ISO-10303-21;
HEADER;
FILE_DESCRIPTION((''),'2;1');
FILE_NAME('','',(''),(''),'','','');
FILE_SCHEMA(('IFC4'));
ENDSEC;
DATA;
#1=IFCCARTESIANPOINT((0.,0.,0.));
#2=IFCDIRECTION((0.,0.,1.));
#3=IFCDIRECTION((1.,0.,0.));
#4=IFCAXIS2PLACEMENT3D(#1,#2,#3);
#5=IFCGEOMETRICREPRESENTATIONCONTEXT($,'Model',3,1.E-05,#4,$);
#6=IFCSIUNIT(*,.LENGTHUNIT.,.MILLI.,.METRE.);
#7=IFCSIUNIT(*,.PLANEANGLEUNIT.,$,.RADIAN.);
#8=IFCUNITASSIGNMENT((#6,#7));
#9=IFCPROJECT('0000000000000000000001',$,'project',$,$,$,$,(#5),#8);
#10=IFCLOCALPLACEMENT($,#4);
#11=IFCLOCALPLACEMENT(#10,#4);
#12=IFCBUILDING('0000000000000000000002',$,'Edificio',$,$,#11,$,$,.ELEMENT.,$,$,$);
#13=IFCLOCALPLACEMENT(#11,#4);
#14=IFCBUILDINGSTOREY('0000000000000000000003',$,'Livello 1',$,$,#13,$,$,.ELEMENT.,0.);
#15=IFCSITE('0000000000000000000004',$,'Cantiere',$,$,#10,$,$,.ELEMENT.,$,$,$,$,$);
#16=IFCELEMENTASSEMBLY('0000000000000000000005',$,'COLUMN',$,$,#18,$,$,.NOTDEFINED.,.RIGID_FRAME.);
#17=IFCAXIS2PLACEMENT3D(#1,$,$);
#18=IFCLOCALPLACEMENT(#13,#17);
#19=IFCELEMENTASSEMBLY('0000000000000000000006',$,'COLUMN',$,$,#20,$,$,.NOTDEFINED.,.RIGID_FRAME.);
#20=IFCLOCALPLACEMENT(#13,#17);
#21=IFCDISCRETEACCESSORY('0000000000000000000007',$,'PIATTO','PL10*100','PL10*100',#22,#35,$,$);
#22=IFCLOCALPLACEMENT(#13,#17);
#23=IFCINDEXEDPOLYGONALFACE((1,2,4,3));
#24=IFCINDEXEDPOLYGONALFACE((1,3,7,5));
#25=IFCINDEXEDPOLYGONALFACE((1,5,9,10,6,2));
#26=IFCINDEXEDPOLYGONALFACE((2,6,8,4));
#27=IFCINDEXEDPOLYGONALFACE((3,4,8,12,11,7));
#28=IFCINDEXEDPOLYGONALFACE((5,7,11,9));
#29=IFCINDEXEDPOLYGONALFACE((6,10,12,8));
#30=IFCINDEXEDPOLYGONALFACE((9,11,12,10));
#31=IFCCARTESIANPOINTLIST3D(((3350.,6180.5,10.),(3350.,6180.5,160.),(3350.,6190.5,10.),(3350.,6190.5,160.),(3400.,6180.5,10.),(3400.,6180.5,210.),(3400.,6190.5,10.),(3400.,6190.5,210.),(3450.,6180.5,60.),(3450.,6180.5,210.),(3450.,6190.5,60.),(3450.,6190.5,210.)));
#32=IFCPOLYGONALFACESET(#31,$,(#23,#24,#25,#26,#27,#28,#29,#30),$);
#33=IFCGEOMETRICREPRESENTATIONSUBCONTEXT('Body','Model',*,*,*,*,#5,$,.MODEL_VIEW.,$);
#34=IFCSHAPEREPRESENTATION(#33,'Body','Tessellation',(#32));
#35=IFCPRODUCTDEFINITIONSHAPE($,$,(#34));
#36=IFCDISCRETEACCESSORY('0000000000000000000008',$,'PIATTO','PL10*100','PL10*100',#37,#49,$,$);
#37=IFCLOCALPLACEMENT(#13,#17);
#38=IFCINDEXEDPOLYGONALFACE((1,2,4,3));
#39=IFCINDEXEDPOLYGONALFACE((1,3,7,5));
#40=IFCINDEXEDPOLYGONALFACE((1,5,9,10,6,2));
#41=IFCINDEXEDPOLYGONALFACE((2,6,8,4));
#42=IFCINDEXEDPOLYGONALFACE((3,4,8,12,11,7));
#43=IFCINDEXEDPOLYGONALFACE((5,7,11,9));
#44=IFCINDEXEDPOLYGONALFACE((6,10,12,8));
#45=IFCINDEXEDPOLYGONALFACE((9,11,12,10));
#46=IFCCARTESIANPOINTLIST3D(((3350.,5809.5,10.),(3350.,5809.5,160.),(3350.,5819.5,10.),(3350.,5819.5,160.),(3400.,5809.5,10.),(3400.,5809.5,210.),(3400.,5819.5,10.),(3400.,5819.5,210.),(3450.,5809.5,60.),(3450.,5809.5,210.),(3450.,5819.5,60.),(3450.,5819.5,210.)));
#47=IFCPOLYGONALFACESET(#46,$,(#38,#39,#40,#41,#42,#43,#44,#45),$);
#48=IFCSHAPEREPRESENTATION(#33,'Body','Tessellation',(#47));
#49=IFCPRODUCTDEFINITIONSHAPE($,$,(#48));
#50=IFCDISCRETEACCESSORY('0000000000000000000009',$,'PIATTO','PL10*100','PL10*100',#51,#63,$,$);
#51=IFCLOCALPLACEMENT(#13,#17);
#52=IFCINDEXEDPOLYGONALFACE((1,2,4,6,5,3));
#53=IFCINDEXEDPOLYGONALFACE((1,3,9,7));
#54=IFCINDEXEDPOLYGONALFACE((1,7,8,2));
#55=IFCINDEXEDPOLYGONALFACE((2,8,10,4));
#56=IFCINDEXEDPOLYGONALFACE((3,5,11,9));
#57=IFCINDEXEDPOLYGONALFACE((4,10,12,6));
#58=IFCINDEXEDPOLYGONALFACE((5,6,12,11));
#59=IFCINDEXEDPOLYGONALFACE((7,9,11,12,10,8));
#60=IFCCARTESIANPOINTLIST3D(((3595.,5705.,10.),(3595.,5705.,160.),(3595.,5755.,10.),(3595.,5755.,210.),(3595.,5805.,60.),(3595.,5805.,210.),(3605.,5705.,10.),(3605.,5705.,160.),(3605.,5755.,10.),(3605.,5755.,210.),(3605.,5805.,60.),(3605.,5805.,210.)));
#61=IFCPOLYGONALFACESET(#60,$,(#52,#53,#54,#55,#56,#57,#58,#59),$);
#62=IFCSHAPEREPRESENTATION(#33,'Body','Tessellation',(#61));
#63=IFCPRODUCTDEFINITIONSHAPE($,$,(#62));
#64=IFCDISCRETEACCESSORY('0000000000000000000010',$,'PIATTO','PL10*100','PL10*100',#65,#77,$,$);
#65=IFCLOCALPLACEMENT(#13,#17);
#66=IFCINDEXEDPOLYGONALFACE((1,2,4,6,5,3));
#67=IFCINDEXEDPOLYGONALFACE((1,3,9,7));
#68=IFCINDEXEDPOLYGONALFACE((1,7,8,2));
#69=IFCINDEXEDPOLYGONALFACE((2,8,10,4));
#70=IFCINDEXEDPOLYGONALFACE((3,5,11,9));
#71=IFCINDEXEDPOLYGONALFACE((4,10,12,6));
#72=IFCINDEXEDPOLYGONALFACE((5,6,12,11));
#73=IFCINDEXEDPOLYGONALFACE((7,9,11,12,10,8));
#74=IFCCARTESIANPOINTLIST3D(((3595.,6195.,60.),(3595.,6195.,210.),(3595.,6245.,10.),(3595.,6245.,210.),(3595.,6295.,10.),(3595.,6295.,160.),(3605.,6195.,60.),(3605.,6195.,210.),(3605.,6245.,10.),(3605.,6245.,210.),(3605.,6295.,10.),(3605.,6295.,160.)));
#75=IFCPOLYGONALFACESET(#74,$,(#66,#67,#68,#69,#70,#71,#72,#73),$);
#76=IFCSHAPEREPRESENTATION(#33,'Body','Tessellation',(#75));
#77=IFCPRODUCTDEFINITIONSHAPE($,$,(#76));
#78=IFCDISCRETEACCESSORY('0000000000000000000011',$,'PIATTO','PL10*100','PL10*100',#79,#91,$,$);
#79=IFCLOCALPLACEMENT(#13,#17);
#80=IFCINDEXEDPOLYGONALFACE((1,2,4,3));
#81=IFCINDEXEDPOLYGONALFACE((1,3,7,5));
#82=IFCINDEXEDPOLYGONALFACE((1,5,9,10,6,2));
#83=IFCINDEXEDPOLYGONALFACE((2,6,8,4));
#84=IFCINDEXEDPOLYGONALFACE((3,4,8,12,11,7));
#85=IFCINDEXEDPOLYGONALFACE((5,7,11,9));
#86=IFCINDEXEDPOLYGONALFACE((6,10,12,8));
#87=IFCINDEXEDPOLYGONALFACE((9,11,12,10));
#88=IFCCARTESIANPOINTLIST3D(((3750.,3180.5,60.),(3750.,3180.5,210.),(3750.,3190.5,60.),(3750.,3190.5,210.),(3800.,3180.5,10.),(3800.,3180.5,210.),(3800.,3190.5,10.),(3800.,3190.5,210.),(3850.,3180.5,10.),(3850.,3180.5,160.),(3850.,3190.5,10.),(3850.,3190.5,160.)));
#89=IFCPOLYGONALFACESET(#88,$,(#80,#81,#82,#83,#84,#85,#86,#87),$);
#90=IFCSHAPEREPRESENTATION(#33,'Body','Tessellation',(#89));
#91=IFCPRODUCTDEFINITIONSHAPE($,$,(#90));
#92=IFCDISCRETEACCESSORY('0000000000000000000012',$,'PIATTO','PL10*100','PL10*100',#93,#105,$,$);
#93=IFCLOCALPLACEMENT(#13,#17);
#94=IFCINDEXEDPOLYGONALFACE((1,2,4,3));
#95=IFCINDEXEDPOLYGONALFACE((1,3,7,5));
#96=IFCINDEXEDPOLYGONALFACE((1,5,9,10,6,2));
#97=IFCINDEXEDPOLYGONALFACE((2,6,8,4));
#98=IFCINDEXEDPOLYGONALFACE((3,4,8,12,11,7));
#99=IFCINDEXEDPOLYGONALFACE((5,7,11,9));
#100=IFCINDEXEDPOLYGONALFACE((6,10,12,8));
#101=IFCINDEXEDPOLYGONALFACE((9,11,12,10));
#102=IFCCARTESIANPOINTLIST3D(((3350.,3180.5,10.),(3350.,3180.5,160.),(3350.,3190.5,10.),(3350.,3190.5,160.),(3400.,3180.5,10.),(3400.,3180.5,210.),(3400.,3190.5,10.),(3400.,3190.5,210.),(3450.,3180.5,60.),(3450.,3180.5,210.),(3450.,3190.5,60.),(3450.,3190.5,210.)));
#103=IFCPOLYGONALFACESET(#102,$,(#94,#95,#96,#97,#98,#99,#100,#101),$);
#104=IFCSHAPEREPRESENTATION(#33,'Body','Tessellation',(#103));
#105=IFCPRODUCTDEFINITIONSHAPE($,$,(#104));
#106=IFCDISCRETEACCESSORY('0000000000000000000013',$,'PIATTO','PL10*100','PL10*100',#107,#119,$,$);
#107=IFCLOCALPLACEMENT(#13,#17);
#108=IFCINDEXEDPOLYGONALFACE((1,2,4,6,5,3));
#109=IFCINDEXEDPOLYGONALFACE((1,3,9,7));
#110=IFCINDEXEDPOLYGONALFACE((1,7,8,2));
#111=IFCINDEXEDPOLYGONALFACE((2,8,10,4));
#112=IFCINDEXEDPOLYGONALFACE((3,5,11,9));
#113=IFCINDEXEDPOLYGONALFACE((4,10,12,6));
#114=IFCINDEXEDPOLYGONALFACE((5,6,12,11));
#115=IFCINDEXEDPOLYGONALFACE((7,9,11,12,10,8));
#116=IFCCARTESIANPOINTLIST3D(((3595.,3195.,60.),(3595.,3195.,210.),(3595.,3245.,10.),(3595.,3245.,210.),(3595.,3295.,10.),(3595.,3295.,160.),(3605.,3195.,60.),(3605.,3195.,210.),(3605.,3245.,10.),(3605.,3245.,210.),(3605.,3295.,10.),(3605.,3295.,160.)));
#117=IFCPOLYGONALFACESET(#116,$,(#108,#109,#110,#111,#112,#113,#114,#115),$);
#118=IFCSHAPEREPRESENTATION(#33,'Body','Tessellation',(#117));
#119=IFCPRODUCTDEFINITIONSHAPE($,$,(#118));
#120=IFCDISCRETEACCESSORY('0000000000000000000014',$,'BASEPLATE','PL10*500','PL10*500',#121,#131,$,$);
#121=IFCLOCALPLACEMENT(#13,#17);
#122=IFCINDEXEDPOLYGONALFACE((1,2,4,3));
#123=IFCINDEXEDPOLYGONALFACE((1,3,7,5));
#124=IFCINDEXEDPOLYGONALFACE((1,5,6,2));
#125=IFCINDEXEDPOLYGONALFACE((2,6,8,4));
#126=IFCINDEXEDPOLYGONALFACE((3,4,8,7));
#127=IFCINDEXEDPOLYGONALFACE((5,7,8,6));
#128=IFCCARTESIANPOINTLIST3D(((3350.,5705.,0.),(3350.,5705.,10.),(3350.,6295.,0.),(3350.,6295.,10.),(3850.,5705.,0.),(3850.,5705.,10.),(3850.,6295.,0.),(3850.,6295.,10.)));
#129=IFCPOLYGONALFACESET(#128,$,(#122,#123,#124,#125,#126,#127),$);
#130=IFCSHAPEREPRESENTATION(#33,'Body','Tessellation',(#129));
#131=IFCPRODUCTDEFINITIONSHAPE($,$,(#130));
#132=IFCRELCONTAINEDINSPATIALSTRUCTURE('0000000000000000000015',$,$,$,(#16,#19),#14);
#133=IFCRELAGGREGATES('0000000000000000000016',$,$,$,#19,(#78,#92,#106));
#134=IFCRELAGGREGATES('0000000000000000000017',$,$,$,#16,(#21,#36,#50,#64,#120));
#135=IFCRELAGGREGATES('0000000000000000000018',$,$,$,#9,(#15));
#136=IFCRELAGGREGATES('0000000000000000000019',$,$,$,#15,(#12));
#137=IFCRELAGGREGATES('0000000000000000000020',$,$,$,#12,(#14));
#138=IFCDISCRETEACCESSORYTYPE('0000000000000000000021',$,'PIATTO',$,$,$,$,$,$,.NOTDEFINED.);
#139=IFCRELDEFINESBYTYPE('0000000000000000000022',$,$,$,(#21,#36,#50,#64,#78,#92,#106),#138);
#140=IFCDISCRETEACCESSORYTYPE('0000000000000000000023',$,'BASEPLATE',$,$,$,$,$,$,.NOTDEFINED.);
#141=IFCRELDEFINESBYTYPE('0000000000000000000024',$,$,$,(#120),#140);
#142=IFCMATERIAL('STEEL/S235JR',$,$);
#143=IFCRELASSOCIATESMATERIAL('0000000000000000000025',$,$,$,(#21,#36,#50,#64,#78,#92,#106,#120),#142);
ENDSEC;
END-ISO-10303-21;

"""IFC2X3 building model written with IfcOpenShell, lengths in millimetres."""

from ifc_helpers import new_model, si_unit, frame, origin_with_axes, place, context, subcontext, project, spatial, polyline, outline, extrude, material, type_object, element, aggregate, save


model = new_model("IFC2X3")

# Units and contexts
model_context = context("Model", 3, precision=1e-05, world=origin_with_axes())
body_context = subcontext(model_context, "Body", "Model", "MODEL_VIEW")
ifc_project = project(units=[si_unit("LENGTHUNIT", "METRE", prefix="MILLI"), si_unit("PLANEANGLEUNIT", "RADIAN")], contexts=[model_context])

# Site, building, storey
site_placement = place(None, origin_with_axes())
site = spatial("IfcSite", under=ifc_project, at=site_placement, Name="Cantiere", CompositionType="ELEMENT")
building_placement = place(site_placement, origin_with_axes())
building = spatial("IfcBuilding", under=site, at=building_placement, Name="Edificio", CompositionType="ELEMENT")
storey_placement = place(building_placement, origin_with_axes())
storey = spatial("IfcBuildingStorey", under=building, at=storey_placement, Name="Livello 1", CompositionType="ELEMENT", Elevation=0.0)

# Element assembly
assembly_1_placement = place(storey_placement, origin_with_axes())
assembly_1 = element("IfcElementAssembly", 1, at=assembly_1_placement, inside=storey, Name="COLUMN", AssemblyPlace="NOTDEFINED", PredefinedType="RIGID_FRAME")
ifc_material_1 = material(Name="STEEL/S235JR")
discrete_accessory_type_1 = type_object("IfcDiscreteAccessoryType", Name="PIATTO")

# Element assembly
assembly_2_placement = place(storey_placement, origin_with_axes())
assembly_2 = element("IfcElementAssembly", 2, at=assembly_2_placement, inside=storey, Name="COLUMN", AssemblyPlace="NOTDEFINED", PredefinedType="RIGID_FRAME")

# Discrete accessories
discrete_accessory_1_placement = place(assembly_1_placement, frame((3450.0, 6185.5, 60.0), z_axis=(0.0, 1.0, 0.0), x_axis=(-0.707107, 0.0, -0.707107)))
discrete_accessory_1 = element("IfcDiscreteAccessory", 3, at=discrete_accessory_1_placement, type_object=discrete_accessory_type_1, material=ifc_material_1, Name="PIATTO", Description="PL10*100", ObjectType="PL10*100", context=body_context, shape_type="SweptSolid", body=[
    extrude(outline(polyline([(0.0, 0.0), (70.7, 0.0), (106.1, 35.4), (0.0, 141.4), (-70.7, 141.4), (-106.1, 106.1), (0.0, 0.0)])), frame((0.0, 0.0, -5.0), z_axis=(0.0, 0.0, 1.0), x_axis=(1.0, 0.0, 0.0)), (0.0, 0.0, 1.0), 10.0),
])
discrete_accessory_2_placement = place(assembly_1_placement, frame((3450.0, 5814.5, 60.0), z_axis=(0.0, 1.0, 0.0), x_axis=(-0.707107, 0.0, -0.707107)))
discrete_accessory_2 = element("IfcDiscreteAccessory", 4, at=discrete_accessory_2_placement, type_object=discrete_accessory_type_1, material=ifc_material_1, Name="PIATTO", Description="PL10*100", ObjectType="PL10*100", context=body_context, shape_type="SweptSolid", body=[
    extrude(outline(polyline([(0.0, 0.0), (70.7, 0.0), (106.1, 35.4), (0.0, 141.4), (-70.7, 141.4), (-106.1, 106.1), (0.0, 0.0)])), frame((0.0, 0.0, -5.0), z_axis=(0.0, 0.0, 1.0), x_axis=(1.0, 0.0, 0.0)), (0.0, 0.0, 1.0), 10.0),
])
discrete_accessory_3_placement = place(assembly_1_placement, frame((3600.0, 5805.0, 60.0), z_axis=(-1.0, 0.0, 0.0), x_axis=(0.0, -0.707107, -0.707107)))
discrete_accessory_3 = element("IfcDiscreteAccessory", 5, at=discrete_accessory_3_placement, type_object=discrete_accessory_type_1, material=ifc_material_1, Name="PIATTO", Description="PL10*100", ObjectType="PL10*100", context=body_context, shape_type="SweptSolid", body=[
    extrude(outline(polyline([(0.0, 0.0), (70.7, 0.0), (106.1, 35.4), (0.0, 141.4), (-70.7, 141.4), (-106.1, 106.1), (0.0, 0.0)])), frame((0.0, 0.0, -5.0), z_axis=(0.0, 0.0, 1.0), x_axis=(1.0, 0.0, 0.0)), (0.0, 0.0, 1.0), 10.0),
])
discrete_accessory_4_placement = place(assembly_1_placement, frame((3600.0, 6195.0, 60.0), z_axis=(1.0, 0.0, 0.0), x_axis=(0.0, 0.707107, -0.707107)))
discrete_accessory_4 = element("IfcDiscreteAccessory", 6, at=discrete_accessory_4_placement, type_object=discrete_accessory_type_1, material=ifc_material_1, Name="PIATTO", Description="PL10*100", ObjectType="PL10*100", context=body_context, shape_type="SweptSolid", body=[
    extrude(outline(polyline([(0.0, 0.0), (70.7, 0.0), (106.1, 35.4), (0.0, 141.4), (-70.7, 141.4), (-106.1, 106.1), (0.0, 0.0)])), frame((0.0, 0.0, -5.0), z_axis=(0.0, 0.0, 1.0), x_axis=(1.0, 0.0, 0.0)), (0.0, 0.0, 1.0), 10.0),
])
discrete_accessory_5_placement = place(assembly_2_placement, frame((3750.0, 3185.5, 60.0), z_axis=(0.0, -1.0, 0.0), x_axis=(0.707107, 0.0, -0.707107)))
discrete_accessory_5 = element("IfcDiscreteAccessory", 7, at=discrete_accessory_5_placement, type_object=discrete_accessory_type_1, material=ifc_material_1, Name="PIATTO", Description="PL10*100", ObjectType="PL10*100", context=body_context, shape_type="SweptSolid", body=[
    extrude(outline(polyline([(0.0, 0.0), (70.7, 0.0), (106.1, 35.4), (0.0, 141.4), (-70.7, 141.4), (-106.1, 106.1), (0.0, 0.0)])), frame((0.0, 0.0, -5.0), z_axis=(0.0, 0.0, 1.0), x_axis=(1.0, 0.0, 0.0)), (0.0, 0.0, 1.0), 10.0),
])
discrete_accessory_6_placement = place(assembly_2_placement, frame((3450.0, 3185.5, 60.0), z_axis=(0.0, 1.0, 0.0), x_axis=(-0.707107, 0.0, -0.707107)))
discrete_accessory_6 = element("IfcDiscreteAccessory", 8, at=discrete_accessory_6_placement, type_object=discrete_accessory_type_1, material=ifc_material_1, Name="PIATTO", Description="PL10*100", ObjectType="PL10*100", context=body_context, shape_type="SweptSolid", body=[
    extrude(outline(polyline([(0.0, 0.0), (70.7, 0.0), (106.1, 35.4), (0.0, 141.4), (-70.7, 141.4), (-106.1, 106.1), (0.0, 0.0)])), frame((0.0, 0.0, -5.0), z_axis=(0.0, 0.0, 1.0), x_axis=(1.0, 0.0, 0.0)), (0.0, 0.0, 1.0), 10.0),
])
discrete_accessory_7_placement = place(assembly_2_placement, frame((3600.0, 3195.0, 60.0), z_axis=(1.0, 0.0, 0.0), x_axis=(0.0, 0.707107, -0.707107)))
discrete_accessory_7 = element("IfcDiscreteAccessory", 9, at=discrete_accessory_7_placement, type_object=discrete_accessory_type_1, material=ifc_material_1, Name="PIATTO", Description="PL10*100", ObjectType="PL10*100", context=body_context, shape_type="SweptSolid", body=[
    extrude(outline(polyline([(0.0, 0.0), (70.7, 0.0), (106.1, 35.4), (0.0, 141.4), (-70.7, 141.4), (-106.1, 106.1), (0.0, 0.0)])), frame((0.0, 0.0, -5.0), z_axis=(0.0, 0.0, 1.0), x_axis=(1.0, 0.0, 0.0)), (0.0, 0.0, 1.0), 10.0),
])

aggregate(assembly_2, [discrete_accessory_5, discrete_accessory_6, discrete_accessory_7])

# Discrete accessory
discrete_accessory_type_2 = type_object("IfcDiscreteAccessoryType", Name="BASEPLATE")
discrete_accessory_8_placement = place(assembly_1_placement, frame((3600.0, 5705.0, 5.0), z_axis=(0.0, 0.0, 1.0), x_axis=(0.0, 1.0, 0.0)))
discrete_accessory_8 = element("IfcDiscreteAccessory", 10, at=discrete_accessory_8_placement, type_object=discrete_accessory_type_2, material=ifc_material_1, Name="BASEPLATE", Description="PL10*500", ObjectType="PL10*500", context=body_context, shape_type="SweptSolid", body=[
    extrude(outline(polyline([(0.0, 250.0), (590.0, 250.0), (590.0, -250.0), (0.0, -250.0), (0.0, 250.0)])), frame((0.0, 0.0, -5.0), z_axis=(0.0, 0.0, 1.0), x_axis=(1.0, 0.0, 0.0)), (0.0, 0.0, 1.0), 10.0),
])
aggregate(assembly_1, [discrete_accessory_1, discrete_accessory_2, discrete_accessory_3, discrete_accessory_4, discrete_accessory_8])

save(model, "model.ifc")
